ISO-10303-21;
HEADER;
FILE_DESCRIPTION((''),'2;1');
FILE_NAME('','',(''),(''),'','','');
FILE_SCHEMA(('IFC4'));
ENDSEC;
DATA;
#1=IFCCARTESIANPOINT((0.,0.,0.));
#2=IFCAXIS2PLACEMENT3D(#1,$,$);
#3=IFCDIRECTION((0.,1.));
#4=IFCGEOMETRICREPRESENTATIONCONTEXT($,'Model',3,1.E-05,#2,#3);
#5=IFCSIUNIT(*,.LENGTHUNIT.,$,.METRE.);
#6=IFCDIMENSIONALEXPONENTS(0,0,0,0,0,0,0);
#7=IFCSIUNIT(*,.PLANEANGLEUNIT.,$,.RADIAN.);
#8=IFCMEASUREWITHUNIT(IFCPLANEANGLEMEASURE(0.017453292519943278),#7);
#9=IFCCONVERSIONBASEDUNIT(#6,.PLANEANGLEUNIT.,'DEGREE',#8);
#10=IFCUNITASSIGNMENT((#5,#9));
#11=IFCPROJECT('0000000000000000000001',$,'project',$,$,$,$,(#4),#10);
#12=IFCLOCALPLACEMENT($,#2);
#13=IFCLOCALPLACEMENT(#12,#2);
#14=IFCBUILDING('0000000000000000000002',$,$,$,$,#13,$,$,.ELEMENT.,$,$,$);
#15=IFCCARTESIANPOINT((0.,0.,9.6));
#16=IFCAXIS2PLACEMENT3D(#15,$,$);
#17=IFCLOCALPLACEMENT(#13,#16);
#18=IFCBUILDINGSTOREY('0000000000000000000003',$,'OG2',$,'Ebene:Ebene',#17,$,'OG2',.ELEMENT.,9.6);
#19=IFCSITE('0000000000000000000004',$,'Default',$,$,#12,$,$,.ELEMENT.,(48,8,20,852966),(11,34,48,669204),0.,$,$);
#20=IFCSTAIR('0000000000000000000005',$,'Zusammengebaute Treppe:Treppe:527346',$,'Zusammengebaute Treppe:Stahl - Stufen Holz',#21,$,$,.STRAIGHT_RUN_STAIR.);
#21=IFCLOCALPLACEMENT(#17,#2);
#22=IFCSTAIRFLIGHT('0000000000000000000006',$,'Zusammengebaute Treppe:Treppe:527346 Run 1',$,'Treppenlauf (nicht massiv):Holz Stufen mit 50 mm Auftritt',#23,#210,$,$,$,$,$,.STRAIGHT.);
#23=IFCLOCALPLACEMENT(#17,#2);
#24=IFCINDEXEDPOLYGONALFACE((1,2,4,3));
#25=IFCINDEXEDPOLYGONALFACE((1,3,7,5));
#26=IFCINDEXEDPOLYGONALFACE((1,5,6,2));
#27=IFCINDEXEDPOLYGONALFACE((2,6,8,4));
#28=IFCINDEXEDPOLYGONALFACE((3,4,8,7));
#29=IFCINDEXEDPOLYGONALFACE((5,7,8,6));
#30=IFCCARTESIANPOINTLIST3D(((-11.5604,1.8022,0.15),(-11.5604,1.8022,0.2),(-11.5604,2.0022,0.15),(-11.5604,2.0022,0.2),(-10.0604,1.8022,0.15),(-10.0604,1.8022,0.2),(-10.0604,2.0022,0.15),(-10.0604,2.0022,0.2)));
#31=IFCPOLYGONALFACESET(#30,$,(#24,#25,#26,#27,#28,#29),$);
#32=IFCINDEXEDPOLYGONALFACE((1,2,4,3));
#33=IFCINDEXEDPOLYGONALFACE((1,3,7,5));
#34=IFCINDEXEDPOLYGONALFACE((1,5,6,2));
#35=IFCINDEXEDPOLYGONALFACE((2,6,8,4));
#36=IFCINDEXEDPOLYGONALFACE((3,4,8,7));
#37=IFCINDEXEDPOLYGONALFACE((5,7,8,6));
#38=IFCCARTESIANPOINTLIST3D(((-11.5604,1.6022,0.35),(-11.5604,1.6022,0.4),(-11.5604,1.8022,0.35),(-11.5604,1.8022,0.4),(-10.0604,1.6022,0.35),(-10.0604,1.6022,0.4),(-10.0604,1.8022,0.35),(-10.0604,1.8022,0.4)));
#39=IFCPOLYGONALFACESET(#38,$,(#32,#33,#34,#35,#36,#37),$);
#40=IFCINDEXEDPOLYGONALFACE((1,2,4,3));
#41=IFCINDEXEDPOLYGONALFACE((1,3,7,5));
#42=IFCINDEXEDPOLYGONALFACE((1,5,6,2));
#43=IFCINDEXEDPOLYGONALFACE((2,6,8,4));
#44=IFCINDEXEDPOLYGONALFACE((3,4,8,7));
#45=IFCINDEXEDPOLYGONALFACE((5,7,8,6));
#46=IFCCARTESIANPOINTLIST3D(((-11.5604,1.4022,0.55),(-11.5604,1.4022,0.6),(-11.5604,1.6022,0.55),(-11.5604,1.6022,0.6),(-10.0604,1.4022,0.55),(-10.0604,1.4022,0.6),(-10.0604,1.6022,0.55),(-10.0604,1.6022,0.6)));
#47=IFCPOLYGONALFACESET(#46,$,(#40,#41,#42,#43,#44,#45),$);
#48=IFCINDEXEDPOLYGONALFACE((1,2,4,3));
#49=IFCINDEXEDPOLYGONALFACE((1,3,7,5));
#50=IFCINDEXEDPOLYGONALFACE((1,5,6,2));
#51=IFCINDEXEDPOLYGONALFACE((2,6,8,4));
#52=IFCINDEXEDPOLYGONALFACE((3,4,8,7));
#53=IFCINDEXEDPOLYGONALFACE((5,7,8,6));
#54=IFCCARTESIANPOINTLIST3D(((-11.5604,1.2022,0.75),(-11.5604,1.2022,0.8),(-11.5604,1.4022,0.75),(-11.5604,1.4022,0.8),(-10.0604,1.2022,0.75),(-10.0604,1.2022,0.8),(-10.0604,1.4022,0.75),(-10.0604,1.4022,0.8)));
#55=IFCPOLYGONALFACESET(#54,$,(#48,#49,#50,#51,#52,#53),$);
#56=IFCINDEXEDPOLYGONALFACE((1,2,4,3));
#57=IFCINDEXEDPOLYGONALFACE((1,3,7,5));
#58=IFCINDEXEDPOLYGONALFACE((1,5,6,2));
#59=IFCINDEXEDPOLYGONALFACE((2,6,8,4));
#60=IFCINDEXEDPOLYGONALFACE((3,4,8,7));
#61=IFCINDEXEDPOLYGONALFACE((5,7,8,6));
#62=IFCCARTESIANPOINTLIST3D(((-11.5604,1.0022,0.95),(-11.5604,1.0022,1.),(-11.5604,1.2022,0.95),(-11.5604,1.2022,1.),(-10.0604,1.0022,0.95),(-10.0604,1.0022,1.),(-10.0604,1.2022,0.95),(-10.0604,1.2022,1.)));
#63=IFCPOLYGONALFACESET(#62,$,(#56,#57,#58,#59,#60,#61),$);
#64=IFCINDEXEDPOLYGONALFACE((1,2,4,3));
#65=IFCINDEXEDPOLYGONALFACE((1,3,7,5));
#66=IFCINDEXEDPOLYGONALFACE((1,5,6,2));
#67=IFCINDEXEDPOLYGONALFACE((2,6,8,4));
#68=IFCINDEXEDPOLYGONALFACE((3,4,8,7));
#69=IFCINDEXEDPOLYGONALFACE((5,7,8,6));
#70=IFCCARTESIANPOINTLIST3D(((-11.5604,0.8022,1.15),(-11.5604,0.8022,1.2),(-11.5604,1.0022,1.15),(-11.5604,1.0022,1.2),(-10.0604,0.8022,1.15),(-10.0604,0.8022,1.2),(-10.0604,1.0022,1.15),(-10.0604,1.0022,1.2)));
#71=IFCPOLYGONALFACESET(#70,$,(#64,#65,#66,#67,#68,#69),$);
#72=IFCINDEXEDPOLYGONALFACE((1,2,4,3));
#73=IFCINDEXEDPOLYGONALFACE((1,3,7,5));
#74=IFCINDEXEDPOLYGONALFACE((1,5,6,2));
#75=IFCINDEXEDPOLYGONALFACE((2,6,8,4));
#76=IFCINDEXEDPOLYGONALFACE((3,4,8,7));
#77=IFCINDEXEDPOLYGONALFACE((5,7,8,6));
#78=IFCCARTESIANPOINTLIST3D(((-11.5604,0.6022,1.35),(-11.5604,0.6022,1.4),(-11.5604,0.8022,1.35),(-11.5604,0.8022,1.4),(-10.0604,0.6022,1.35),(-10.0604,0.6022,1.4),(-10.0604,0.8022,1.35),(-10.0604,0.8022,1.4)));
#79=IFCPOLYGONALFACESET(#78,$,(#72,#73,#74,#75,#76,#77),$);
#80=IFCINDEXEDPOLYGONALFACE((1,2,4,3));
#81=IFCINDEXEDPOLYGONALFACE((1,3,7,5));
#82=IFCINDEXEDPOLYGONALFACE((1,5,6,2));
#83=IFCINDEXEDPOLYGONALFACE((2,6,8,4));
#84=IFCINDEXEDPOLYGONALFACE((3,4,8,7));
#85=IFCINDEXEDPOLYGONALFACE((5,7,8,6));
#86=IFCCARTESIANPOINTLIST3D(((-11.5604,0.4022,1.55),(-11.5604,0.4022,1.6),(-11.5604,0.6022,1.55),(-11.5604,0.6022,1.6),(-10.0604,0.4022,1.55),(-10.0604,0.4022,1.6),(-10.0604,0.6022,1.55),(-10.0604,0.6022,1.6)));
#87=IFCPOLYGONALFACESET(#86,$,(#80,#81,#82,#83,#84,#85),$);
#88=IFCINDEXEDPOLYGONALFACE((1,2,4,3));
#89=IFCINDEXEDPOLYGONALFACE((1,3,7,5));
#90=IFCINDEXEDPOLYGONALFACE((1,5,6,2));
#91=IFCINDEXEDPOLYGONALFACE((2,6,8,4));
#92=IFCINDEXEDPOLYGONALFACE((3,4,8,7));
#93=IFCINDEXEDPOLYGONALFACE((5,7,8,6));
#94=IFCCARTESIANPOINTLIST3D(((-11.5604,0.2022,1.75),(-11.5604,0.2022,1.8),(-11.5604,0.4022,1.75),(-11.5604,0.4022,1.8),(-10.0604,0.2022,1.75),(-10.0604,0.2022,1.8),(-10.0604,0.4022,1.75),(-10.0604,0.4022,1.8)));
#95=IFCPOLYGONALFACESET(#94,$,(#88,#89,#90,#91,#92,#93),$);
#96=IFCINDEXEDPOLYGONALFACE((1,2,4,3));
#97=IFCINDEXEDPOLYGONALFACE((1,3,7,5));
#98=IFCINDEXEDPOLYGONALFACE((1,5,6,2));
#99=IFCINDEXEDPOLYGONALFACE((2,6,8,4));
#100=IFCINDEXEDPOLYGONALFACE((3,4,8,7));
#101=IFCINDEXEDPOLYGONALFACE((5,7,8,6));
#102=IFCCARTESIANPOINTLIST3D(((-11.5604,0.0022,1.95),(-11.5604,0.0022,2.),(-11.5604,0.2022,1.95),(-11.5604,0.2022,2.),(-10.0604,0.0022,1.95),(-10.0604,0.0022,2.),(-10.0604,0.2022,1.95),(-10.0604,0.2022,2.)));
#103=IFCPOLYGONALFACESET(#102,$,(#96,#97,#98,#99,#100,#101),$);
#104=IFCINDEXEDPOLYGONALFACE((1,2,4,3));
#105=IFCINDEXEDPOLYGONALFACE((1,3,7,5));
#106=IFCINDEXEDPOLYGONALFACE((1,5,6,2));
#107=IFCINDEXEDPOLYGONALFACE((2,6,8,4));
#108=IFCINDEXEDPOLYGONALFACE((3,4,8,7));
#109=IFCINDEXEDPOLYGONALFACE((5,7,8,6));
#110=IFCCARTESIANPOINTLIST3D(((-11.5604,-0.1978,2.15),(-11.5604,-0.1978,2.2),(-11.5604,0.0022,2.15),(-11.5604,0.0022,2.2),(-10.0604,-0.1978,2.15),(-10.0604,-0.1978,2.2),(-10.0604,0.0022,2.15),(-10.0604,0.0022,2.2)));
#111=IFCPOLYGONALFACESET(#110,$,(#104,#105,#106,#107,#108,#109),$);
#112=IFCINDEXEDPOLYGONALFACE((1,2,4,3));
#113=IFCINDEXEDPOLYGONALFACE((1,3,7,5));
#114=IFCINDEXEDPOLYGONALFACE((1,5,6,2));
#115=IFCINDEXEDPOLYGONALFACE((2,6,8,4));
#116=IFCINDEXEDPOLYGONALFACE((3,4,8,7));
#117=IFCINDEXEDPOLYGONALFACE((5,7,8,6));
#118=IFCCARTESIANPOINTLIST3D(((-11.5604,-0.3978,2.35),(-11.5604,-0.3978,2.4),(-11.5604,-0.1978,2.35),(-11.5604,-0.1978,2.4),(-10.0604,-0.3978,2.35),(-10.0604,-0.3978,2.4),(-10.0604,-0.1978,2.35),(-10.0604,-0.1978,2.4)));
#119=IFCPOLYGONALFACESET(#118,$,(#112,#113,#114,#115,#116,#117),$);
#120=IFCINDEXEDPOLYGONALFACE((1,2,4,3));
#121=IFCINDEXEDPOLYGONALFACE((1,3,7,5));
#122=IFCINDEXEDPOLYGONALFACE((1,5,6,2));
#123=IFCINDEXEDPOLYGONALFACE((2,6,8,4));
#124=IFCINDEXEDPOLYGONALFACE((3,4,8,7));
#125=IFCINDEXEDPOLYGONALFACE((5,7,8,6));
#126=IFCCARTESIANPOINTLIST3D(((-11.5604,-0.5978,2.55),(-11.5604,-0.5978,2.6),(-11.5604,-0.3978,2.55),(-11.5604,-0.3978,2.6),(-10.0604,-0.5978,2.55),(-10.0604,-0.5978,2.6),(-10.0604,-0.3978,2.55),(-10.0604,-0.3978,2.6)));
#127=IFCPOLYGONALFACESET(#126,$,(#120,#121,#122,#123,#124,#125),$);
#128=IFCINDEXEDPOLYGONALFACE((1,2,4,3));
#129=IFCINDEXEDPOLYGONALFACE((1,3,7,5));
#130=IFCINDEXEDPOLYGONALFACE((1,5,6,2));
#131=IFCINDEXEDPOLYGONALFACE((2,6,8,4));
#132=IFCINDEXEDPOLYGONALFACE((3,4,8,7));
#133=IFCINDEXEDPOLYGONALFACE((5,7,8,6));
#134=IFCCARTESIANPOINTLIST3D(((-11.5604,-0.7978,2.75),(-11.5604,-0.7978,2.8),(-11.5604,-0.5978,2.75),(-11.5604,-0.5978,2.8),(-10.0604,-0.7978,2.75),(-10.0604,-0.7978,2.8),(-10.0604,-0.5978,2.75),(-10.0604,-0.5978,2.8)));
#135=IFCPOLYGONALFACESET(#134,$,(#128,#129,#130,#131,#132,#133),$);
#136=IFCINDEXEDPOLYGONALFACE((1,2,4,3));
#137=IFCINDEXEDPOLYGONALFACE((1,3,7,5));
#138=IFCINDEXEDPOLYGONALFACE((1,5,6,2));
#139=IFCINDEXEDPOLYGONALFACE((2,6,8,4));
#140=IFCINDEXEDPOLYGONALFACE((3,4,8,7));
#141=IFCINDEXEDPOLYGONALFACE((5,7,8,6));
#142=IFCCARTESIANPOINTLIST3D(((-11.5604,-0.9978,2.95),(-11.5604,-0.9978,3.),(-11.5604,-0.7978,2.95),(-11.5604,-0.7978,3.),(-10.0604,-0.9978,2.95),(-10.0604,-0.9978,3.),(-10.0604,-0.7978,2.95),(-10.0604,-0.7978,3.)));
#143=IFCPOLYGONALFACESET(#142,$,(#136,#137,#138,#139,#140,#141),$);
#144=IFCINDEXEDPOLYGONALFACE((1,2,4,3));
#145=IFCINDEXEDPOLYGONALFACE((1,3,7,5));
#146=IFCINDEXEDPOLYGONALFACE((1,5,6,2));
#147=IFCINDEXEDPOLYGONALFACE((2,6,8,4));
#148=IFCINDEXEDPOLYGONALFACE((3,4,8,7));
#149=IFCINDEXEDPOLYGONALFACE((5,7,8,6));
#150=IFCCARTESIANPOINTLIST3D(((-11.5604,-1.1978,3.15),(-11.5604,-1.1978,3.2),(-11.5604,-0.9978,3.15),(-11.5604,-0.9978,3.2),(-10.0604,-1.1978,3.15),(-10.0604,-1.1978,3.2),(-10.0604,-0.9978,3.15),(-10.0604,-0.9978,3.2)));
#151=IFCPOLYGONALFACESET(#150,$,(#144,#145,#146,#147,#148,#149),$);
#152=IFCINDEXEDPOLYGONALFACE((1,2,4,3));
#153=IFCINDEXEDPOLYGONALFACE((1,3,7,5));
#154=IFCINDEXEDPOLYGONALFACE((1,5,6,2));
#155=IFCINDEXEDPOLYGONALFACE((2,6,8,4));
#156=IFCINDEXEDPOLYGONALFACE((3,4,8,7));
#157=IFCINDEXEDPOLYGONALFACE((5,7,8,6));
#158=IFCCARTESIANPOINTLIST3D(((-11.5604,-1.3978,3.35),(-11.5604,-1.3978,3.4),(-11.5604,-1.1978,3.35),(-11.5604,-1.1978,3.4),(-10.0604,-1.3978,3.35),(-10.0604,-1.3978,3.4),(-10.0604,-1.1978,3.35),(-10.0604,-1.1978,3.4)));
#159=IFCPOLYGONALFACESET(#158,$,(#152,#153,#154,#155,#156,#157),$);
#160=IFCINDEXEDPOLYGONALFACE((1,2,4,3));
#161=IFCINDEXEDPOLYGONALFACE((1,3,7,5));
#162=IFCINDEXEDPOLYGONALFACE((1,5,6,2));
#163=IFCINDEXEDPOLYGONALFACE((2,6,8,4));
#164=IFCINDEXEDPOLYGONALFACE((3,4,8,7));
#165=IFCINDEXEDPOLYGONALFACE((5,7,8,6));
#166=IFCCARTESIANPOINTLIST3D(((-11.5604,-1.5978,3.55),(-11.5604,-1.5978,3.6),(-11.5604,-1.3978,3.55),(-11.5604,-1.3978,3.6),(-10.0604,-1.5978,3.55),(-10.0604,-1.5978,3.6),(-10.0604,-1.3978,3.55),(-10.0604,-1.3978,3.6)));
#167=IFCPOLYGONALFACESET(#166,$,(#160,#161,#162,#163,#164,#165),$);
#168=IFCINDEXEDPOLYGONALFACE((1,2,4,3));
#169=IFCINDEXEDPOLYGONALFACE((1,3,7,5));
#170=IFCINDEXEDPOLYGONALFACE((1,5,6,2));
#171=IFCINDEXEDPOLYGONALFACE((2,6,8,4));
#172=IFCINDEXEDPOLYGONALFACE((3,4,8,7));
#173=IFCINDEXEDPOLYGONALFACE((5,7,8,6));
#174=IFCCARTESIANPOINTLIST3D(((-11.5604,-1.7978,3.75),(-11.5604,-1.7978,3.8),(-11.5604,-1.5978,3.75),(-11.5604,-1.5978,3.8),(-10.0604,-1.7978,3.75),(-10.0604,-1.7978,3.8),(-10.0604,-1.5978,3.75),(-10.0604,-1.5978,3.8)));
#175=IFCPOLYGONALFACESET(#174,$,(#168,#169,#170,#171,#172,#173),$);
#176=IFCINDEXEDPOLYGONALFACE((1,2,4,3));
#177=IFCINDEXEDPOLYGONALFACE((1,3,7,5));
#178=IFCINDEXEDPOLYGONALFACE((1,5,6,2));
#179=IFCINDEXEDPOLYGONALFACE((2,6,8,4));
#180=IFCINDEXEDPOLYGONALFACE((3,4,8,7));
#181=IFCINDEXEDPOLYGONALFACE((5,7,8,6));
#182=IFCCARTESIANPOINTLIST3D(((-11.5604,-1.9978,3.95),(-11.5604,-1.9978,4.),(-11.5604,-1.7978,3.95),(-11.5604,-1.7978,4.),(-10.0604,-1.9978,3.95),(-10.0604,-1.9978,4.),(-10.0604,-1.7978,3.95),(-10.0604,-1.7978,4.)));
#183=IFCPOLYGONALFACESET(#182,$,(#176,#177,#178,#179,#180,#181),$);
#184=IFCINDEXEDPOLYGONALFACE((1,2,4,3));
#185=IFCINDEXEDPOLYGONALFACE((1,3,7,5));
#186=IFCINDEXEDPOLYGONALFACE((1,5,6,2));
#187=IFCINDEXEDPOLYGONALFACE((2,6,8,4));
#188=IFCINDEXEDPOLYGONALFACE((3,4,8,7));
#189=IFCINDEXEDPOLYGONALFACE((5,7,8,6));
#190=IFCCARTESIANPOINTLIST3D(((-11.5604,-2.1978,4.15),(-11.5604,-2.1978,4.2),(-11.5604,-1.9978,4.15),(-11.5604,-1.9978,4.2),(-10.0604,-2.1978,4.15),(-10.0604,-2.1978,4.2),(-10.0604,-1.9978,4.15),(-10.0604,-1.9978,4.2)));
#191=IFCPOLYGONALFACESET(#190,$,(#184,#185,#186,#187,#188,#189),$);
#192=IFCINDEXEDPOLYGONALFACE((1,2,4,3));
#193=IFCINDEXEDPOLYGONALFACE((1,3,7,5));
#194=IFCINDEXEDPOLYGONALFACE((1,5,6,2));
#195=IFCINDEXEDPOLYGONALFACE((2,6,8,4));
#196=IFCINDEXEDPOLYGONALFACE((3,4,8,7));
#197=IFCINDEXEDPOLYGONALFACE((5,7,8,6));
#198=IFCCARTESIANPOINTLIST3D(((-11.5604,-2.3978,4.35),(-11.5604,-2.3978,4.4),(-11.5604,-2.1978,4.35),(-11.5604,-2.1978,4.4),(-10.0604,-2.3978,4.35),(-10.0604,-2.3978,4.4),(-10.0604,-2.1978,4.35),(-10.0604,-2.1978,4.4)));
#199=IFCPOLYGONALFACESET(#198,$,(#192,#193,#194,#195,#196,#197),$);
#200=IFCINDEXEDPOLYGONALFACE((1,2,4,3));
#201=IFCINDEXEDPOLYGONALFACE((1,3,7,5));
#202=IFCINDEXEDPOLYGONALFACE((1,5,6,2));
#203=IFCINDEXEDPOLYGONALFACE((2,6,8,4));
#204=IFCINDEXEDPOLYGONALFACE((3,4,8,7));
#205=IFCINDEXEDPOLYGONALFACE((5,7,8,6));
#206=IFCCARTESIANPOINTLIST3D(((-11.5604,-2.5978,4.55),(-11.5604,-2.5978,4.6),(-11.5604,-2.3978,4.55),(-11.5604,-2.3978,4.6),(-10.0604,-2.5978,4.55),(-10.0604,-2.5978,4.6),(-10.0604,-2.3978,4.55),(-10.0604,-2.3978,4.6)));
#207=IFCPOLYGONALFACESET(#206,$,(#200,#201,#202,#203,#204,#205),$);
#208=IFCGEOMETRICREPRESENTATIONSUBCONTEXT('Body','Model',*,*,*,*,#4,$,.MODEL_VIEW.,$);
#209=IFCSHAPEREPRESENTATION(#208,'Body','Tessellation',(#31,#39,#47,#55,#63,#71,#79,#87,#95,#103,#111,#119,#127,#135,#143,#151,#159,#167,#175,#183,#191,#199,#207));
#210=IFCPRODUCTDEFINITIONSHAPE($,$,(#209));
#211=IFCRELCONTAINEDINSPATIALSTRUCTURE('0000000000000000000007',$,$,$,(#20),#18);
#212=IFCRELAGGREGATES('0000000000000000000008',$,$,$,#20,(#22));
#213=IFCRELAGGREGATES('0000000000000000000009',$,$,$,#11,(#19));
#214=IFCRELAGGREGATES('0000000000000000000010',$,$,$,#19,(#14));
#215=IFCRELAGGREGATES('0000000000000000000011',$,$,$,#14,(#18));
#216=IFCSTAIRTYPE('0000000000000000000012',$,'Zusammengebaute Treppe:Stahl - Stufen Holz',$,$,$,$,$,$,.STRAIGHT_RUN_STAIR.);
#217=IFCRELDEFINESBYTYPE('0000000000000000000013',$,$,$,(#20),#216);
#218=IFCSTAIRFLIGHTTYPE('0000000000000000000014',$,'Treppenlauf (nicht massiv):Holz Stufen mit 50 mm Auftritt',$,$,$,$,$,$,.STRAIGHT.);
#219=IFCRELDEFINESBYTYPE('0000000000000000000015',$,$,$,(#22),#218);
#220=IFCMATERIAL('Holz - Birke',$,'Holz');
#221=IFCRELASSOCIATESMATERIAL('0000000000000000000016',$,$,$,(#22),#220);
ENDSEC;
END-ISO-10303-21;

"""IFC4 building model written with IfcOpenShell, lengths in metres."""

from ifc_helpers import new_model, entity, si_unit, converted_unit, direction, frame, origin, place, context, subcontext, project, spatial, indexed_curve, outline, extrude, material, type_object, element, aggregate, save


model = new_model("IFC4")

# Units and contexts
model_context = context("Model", 3, precision=1e-05, world=origin(), true_north=direction((0.0, 1.0)))
body_context = subcontext(model_context, "Body", "Model", "MODEL_VIEW")
ifc_project = project(units=[si_unit("LENGTHUNIT", "METRE"), converted_unit("PLANEANGLEUNIT", "DEGREE", entity("IfcPlaneAngleMeasure", 0.017453292519943278), si_unit("PLANEANGLEUNIT", "RADIAN"), dimensions=[0, 0, 0, 0, 0, 0, 0])], contexts=[model_context])

# Site, building, storey
site_placement = place(None, origin())
site = spatial("IfcSite", under=ifc_project, at=site_placement, Name="Default", CompositionType="ELEMENT", RefLatitude=(48, 8, 20, 852966), RefLongitude=(11, 34, 48, 669204), RefElevation=0.0)
building_placement = place(site_placement, origin())
building = spatial("IfcBuilding", under=site, at=building_placement, CompositionType="ELEMENT")
storey_placement = place(building_placement, frame((0.0, 0.0, 9.6)))
storey = spatial("IfcBuildingStorey", under=building, at=storey_placement, Name="OG2", ObjectType="Ebene:Ebene", LongName="OG2", CompositionType="ELEMENT", Elevation=9.6)

# Stair
stair_type_1 = type_object("IfcStairType", Name="Zusammengebaute Treppe:Stahl - Stufen Holz", PredefinedType="STRAIGHT_RUN_STAIR")
stair_1_placement = place(storey_placement, origin())
stair_1 = element("IfcStair", 1, at=stair_1_placement, inside=storey, type_object=stair_type_1, Name="Zusammengebaute Treppe:Treppe:527346", ObjectType="Zusammengebaute Treppe:Stahl - Stufen Holz", PredefinedType="STRAIGHT_RUN_STAIR")

# Stair flight
ifc_material_1 = material(Name="Holz - Birke", Category="Holz")
stair_flight_type_1 = type_object("IfcStairFlightType", Name="Treppenlauf (nicht massiv):Holz Stufen mit 50 mm Auftritt", PredefinedType="STRAIGHT")
stair_flight_1_placement = place(stair_1_placement, origin())
stair_flight_1 = element("IfcStairFlight", 2, at=stair_flight_1_placement, type_object=stair_flight_type_1, material=ifc_material_1, Name="Zusammengebaute Treppe:Treppe:527346 Run 1", ObjectType="Treppenlauf (nicht massiv):Holz Stufen mit 50 mm Auftritt", PredefinedType="STRAIGHT", context=body_context, shape_type="SweptSolid", body=[
    extrude(outline(indexed_curve([(-0.1, -0.75), (0.1, -0.75), (0.1, 0.75), (-0.1, 0.75), (-0.1, -0.75)], self_intersect=False)), frame((-10.8104, 1.9022, 0.15), z_axis=(0.0, 0.0, 1.0), x_axis=(0.0, 1.0, 0.0)), (0.0, 0.0, 1.0), 0.05),
    extrude(outline(indexed_curve([(-0.1, -0.75), (0.1, -0.75), (0.1, 0.75), (-0.1, 0.75), (-0.1, -0.75)], self_intersect=False)), frame((-10.8104, 1.7022, 0.35), z_axis=(0.0, 0.0, 1.0), x_axis=(0.0, 1.0, 0.0)), (0.0, 0.0, 1.0), 0.05),
    extrude(outline(indexed_curve([(-0.1, -0.75), (0.1, -0.75), (0.1, 0.75), (-0.1, 0.75), (-0.1, -0.75)], self_intersect=False)), frame((-10.8104, 1.5022, 0.55), z_axis=(0.0, 0.0, 1.0), x_axis=(0.0, 1.0, 0.0)), (0.0, 0.0, 1.0), 0.05),
    extrude(outline(indexed_curve([(-0.1, -0.75), (0.1, -0.75), (0.1, 0.75), (-0.1, 0.75), (-0.1, -0.75)], self_intersect=False)), frame((-10.8104, 1.3022, 0.75), z_axis=(0.0, 0.0, 1.0), x_axis=(0.0, 1.0, 0.0)), (0.0, 0.0, 1.0), 0.05),
    extrude(outline(indexed_curve([(-0.1, -0.75), (0.1, -0.75), (0.1, 0.75), (-0.1, 0.75), (-0.1, -0.75)], self_intersect=False)), frame((-10.8104, 1.1022, 0.95), z_axis=(0.0, 0.0, 1.0), x_axis=(0.0, 1.0, 0.0)), (0.0, 0.0, 1.0), 0.05),
    extrude(outline(indexed_curve([(-0.1, -0.75), (0.1, -0.75), (0.1, 0.75), (-0.1, 0.75), (-0.1, -0.75)], self_intersect=False)), frame((-10.8104, 0.9022, 1.15), z_axis=(0.0, 0.0, 1.0), x_axis=(0.0, 1.0, 0.0)), (0.0, 0.0, 1.0), 0.05),
    extrude(outline(indexed_curve([(-0.1, -0.75), (0.1, -0.75), (0.1, 0.75), (-0.1, 0.75), (-0.1, -0.75)], self_intersect=False)), frame((-10.8104, 0.7022, 1.35), z_axis=(0.0, 0.0, 1.0), x_axis=(0.0, 1.0, 0.0)), (0.0, 0.0, 1.0), 0.05),
    extrude(outline(indexed_curve([(-0.1, -0.75), (0.1, -0.75), (0.1, 0.75), (-0.1, 0.75), (-0.1, -0.75)], self_intersect=False)), frame((-10.8104, 0.5022, 1.55), z_axis=(0.0, 0.0, 1.0), x_axis=(0.0, 1.0, 0.0)), (0.0, 0.0, 1.0), 0.05),
    extrude(outline(indexed_curve([(-0.1, -0.75), (0.1, -0.75), (0.1, 0.75), (-0.1, 0.75), (-0.1, -0.75)], self_intersect=False)), frame((-10.8104, 0.3022, 1.75), z_axis=(0.0, 0.0, 1.0), x_axis=(0.0, 1.0, 0.0)), (0.0, 0.0, 1.0), 0.05),
    extrude(outline(indexed_curve([(-0.1, -0.75), (0.1, -0.75), (0.1, 0.75), (-0.1, 0.75), (-0.1, -0.75)], self_intersect=False)), frame((-10.8104, 0.1022, 1.95), z_axis=(0.0, 0.0, 1.0), x_axis=(0.0, 1.0, 0.0)), (0.0, 0.0, 1.0), 0.05),
    extrude(outline(indexed_curve([(-0.1, -0.75), (0.1, -0.75), (0.1, 0.75), (-0.1, 0.75), (-0.1, -0.75)], self_intersect=False)), frame((-10.8104, -0.0978, 2.15), z_axis=(0.0, 0.0, 1.0), x_axis=(0.0, 1.0, 0.0)), (0.0, 0.0, 1.0), 0.05),
    extrude(outline(indexed_curve([(-0.1, -0.75), (0.1, -0.75), (0.1, 0.75), (-0.1, 0.75), (-0.1, -0.75)], self_intersect=False)), frame((-10.8104, -0.2978, 2.35), z_axis=(0.0, 0.0, 1.0), x_axis=(0.0, 1.0, 0.0)), (0.0, 0.0, 1.0), 0.05),
    extrude(outline(indexed_curve([(-0.1, -0.75), (0.1, -0.75), (0.1, 0.75), (-0.1, 0.75), (-0.1, -0.75)], self_intersect=False)), frame((-10.8104, -0.4978, 2.55), z_axis=(0.0, 0.0, 1.0), x_axis=(0.0, 1.0, 0.0)), (0.0, 0.0, 1.0), 0.05),
    extrude(outline(indexed_curve([(-0.1, -0.75), (0.1, -0.75), (0.1, 0.75), (-0.1, 0.75), (-0.1, -0.75)], self_intersect=False)), frame((-10.8104, -0.6978, 2.75), z_axis=(0.0, 0.0, 1.0), x_axis=(0.0, 1.0, 0.0)), (0.0, 0.0, 1.0), 0.05),
    extrude(outline(indexed_curve([(-0.1, -0.75), (0.1, -0.75), (0.1, 0.75), (-0.1, 0.75), (-0.1, -0.75)], self_intersect=False)), frame((-10.8104, -0.8978, 2.95), z_axis=(0.0, 0.0, 1.0), x_axis=(0.0, 1.0, 0.0)), (0.0, 0.0, 1.0), 0.05),
    extrude(outline(indexed_curve([(-0.1, -0.75), (0.1, -0.75), (0.1, 0.75), (-0.1, 0.75), (-0.1, -0.75)], self_intersect=False)), frame((-10.8104, -1.0978, 3.15), z_axis=(0.0, 0.0, 1.0), x_axis=(0.0, 1.0, 0.0)), (0.0, 0.0, 1.0), 0.05),
    extrude(outline(indexed_curve([(-0.1, -0.75), (0.1, -0.75), (0.1, 0.75), (-0.1, 0.75), (-0.1, -0.75)], self_intersect=False)), frame((-10.8104, -1.2978, 3.35), z_axis=(0.0, 0.0, 1.0), x_axis=(0.0, 1.0, 0.0)), (0.0, 0.0, 1.0), 0.05),
    extrude(outline(indexed_curve([(-0.1, -0.75), (0.1, -0.75), (0.1, 0.75), (-0.1, 0.75), (-0.1, -0.75)], self_intersect=False)), frame((-10.8104, -1.4978, 3.55), z_axis=(0.0, 0.0, 1.0), x_axis=(0.0, 1.0, 0.0)), (0.0, 0.0, 1.0), 0.05),
    extrude(outline(indexed_curve([(-0.1, -0.75), (0.1, -0.75), (0.1, 0.75), (-0.1, 0.75), (-0.1, -0.75)], self_intersect=False)), frame((-10.8104, -1.6978, 3.75), z_axis=(0.0, 0.0, 1.0), x_axis=(0.0, 1.0, 0.0)), (0.0, 0.0, 1.0), 0.05),
    extrude(outline(indexed_curve([(-0.1, -0.75), (0.1, -0.75), (0.1, 0.75), (-0.1, 0.75), (-0.1, -0.75)], self_intersect=False)), frame((-10.8104, -1.8978, 3.95), z_axis=(0.0, 0.0, 1.0), x_axis=(0.0, 1.0, 0.0)), (0.0, 0.0, 1.0), 0.05),
    extrude(outline(indexed_curve([(-0.1, -0.75), (0.1, -0.75), (0.1, 0.75), (-0.1, 0.75), (-0.1, -0.75)], self_intersect=False)), frame((-10.8104, -2.0978, 4.15), z_axis=(0.0, 0.0, 1.0), x_axis=(0.0, 1.0, 0.0)), (0.0, 0.0, 1.0), 0.05),
    extrude(outline(indexed_curve([(-0.1, -0.75), (0.1, -0.75), (0.1, 0.75), (-0.1, 0.75), (-0.1, -0.75)], self_intersect=False)), frame((-10.8104, -2.2978, 4.35), z_axis=(0.0, 0.0, 1.0), x_axis=(0.0, 1.0, 0.0)), (0.0, 0.0, 1.0), 0.05),
    extrude(outline(indexed_curve([(-0.1, -0.75), (0.1, -0.75), (0.1, 0.75), (-0.1, 0.75), (-0.1, -0.75)], self_intersect=False)), frame((-10.8104, -2.4978, 4.55), z_axis=(0.0, 0.0, 1.0), x_axis=(0.0, 1.0, 0.0)), (0.0, 0.0, 1.0), 0.05),
])
aggregate(stair_1, [stair_flight_1])

save(model, "model.ifc")
